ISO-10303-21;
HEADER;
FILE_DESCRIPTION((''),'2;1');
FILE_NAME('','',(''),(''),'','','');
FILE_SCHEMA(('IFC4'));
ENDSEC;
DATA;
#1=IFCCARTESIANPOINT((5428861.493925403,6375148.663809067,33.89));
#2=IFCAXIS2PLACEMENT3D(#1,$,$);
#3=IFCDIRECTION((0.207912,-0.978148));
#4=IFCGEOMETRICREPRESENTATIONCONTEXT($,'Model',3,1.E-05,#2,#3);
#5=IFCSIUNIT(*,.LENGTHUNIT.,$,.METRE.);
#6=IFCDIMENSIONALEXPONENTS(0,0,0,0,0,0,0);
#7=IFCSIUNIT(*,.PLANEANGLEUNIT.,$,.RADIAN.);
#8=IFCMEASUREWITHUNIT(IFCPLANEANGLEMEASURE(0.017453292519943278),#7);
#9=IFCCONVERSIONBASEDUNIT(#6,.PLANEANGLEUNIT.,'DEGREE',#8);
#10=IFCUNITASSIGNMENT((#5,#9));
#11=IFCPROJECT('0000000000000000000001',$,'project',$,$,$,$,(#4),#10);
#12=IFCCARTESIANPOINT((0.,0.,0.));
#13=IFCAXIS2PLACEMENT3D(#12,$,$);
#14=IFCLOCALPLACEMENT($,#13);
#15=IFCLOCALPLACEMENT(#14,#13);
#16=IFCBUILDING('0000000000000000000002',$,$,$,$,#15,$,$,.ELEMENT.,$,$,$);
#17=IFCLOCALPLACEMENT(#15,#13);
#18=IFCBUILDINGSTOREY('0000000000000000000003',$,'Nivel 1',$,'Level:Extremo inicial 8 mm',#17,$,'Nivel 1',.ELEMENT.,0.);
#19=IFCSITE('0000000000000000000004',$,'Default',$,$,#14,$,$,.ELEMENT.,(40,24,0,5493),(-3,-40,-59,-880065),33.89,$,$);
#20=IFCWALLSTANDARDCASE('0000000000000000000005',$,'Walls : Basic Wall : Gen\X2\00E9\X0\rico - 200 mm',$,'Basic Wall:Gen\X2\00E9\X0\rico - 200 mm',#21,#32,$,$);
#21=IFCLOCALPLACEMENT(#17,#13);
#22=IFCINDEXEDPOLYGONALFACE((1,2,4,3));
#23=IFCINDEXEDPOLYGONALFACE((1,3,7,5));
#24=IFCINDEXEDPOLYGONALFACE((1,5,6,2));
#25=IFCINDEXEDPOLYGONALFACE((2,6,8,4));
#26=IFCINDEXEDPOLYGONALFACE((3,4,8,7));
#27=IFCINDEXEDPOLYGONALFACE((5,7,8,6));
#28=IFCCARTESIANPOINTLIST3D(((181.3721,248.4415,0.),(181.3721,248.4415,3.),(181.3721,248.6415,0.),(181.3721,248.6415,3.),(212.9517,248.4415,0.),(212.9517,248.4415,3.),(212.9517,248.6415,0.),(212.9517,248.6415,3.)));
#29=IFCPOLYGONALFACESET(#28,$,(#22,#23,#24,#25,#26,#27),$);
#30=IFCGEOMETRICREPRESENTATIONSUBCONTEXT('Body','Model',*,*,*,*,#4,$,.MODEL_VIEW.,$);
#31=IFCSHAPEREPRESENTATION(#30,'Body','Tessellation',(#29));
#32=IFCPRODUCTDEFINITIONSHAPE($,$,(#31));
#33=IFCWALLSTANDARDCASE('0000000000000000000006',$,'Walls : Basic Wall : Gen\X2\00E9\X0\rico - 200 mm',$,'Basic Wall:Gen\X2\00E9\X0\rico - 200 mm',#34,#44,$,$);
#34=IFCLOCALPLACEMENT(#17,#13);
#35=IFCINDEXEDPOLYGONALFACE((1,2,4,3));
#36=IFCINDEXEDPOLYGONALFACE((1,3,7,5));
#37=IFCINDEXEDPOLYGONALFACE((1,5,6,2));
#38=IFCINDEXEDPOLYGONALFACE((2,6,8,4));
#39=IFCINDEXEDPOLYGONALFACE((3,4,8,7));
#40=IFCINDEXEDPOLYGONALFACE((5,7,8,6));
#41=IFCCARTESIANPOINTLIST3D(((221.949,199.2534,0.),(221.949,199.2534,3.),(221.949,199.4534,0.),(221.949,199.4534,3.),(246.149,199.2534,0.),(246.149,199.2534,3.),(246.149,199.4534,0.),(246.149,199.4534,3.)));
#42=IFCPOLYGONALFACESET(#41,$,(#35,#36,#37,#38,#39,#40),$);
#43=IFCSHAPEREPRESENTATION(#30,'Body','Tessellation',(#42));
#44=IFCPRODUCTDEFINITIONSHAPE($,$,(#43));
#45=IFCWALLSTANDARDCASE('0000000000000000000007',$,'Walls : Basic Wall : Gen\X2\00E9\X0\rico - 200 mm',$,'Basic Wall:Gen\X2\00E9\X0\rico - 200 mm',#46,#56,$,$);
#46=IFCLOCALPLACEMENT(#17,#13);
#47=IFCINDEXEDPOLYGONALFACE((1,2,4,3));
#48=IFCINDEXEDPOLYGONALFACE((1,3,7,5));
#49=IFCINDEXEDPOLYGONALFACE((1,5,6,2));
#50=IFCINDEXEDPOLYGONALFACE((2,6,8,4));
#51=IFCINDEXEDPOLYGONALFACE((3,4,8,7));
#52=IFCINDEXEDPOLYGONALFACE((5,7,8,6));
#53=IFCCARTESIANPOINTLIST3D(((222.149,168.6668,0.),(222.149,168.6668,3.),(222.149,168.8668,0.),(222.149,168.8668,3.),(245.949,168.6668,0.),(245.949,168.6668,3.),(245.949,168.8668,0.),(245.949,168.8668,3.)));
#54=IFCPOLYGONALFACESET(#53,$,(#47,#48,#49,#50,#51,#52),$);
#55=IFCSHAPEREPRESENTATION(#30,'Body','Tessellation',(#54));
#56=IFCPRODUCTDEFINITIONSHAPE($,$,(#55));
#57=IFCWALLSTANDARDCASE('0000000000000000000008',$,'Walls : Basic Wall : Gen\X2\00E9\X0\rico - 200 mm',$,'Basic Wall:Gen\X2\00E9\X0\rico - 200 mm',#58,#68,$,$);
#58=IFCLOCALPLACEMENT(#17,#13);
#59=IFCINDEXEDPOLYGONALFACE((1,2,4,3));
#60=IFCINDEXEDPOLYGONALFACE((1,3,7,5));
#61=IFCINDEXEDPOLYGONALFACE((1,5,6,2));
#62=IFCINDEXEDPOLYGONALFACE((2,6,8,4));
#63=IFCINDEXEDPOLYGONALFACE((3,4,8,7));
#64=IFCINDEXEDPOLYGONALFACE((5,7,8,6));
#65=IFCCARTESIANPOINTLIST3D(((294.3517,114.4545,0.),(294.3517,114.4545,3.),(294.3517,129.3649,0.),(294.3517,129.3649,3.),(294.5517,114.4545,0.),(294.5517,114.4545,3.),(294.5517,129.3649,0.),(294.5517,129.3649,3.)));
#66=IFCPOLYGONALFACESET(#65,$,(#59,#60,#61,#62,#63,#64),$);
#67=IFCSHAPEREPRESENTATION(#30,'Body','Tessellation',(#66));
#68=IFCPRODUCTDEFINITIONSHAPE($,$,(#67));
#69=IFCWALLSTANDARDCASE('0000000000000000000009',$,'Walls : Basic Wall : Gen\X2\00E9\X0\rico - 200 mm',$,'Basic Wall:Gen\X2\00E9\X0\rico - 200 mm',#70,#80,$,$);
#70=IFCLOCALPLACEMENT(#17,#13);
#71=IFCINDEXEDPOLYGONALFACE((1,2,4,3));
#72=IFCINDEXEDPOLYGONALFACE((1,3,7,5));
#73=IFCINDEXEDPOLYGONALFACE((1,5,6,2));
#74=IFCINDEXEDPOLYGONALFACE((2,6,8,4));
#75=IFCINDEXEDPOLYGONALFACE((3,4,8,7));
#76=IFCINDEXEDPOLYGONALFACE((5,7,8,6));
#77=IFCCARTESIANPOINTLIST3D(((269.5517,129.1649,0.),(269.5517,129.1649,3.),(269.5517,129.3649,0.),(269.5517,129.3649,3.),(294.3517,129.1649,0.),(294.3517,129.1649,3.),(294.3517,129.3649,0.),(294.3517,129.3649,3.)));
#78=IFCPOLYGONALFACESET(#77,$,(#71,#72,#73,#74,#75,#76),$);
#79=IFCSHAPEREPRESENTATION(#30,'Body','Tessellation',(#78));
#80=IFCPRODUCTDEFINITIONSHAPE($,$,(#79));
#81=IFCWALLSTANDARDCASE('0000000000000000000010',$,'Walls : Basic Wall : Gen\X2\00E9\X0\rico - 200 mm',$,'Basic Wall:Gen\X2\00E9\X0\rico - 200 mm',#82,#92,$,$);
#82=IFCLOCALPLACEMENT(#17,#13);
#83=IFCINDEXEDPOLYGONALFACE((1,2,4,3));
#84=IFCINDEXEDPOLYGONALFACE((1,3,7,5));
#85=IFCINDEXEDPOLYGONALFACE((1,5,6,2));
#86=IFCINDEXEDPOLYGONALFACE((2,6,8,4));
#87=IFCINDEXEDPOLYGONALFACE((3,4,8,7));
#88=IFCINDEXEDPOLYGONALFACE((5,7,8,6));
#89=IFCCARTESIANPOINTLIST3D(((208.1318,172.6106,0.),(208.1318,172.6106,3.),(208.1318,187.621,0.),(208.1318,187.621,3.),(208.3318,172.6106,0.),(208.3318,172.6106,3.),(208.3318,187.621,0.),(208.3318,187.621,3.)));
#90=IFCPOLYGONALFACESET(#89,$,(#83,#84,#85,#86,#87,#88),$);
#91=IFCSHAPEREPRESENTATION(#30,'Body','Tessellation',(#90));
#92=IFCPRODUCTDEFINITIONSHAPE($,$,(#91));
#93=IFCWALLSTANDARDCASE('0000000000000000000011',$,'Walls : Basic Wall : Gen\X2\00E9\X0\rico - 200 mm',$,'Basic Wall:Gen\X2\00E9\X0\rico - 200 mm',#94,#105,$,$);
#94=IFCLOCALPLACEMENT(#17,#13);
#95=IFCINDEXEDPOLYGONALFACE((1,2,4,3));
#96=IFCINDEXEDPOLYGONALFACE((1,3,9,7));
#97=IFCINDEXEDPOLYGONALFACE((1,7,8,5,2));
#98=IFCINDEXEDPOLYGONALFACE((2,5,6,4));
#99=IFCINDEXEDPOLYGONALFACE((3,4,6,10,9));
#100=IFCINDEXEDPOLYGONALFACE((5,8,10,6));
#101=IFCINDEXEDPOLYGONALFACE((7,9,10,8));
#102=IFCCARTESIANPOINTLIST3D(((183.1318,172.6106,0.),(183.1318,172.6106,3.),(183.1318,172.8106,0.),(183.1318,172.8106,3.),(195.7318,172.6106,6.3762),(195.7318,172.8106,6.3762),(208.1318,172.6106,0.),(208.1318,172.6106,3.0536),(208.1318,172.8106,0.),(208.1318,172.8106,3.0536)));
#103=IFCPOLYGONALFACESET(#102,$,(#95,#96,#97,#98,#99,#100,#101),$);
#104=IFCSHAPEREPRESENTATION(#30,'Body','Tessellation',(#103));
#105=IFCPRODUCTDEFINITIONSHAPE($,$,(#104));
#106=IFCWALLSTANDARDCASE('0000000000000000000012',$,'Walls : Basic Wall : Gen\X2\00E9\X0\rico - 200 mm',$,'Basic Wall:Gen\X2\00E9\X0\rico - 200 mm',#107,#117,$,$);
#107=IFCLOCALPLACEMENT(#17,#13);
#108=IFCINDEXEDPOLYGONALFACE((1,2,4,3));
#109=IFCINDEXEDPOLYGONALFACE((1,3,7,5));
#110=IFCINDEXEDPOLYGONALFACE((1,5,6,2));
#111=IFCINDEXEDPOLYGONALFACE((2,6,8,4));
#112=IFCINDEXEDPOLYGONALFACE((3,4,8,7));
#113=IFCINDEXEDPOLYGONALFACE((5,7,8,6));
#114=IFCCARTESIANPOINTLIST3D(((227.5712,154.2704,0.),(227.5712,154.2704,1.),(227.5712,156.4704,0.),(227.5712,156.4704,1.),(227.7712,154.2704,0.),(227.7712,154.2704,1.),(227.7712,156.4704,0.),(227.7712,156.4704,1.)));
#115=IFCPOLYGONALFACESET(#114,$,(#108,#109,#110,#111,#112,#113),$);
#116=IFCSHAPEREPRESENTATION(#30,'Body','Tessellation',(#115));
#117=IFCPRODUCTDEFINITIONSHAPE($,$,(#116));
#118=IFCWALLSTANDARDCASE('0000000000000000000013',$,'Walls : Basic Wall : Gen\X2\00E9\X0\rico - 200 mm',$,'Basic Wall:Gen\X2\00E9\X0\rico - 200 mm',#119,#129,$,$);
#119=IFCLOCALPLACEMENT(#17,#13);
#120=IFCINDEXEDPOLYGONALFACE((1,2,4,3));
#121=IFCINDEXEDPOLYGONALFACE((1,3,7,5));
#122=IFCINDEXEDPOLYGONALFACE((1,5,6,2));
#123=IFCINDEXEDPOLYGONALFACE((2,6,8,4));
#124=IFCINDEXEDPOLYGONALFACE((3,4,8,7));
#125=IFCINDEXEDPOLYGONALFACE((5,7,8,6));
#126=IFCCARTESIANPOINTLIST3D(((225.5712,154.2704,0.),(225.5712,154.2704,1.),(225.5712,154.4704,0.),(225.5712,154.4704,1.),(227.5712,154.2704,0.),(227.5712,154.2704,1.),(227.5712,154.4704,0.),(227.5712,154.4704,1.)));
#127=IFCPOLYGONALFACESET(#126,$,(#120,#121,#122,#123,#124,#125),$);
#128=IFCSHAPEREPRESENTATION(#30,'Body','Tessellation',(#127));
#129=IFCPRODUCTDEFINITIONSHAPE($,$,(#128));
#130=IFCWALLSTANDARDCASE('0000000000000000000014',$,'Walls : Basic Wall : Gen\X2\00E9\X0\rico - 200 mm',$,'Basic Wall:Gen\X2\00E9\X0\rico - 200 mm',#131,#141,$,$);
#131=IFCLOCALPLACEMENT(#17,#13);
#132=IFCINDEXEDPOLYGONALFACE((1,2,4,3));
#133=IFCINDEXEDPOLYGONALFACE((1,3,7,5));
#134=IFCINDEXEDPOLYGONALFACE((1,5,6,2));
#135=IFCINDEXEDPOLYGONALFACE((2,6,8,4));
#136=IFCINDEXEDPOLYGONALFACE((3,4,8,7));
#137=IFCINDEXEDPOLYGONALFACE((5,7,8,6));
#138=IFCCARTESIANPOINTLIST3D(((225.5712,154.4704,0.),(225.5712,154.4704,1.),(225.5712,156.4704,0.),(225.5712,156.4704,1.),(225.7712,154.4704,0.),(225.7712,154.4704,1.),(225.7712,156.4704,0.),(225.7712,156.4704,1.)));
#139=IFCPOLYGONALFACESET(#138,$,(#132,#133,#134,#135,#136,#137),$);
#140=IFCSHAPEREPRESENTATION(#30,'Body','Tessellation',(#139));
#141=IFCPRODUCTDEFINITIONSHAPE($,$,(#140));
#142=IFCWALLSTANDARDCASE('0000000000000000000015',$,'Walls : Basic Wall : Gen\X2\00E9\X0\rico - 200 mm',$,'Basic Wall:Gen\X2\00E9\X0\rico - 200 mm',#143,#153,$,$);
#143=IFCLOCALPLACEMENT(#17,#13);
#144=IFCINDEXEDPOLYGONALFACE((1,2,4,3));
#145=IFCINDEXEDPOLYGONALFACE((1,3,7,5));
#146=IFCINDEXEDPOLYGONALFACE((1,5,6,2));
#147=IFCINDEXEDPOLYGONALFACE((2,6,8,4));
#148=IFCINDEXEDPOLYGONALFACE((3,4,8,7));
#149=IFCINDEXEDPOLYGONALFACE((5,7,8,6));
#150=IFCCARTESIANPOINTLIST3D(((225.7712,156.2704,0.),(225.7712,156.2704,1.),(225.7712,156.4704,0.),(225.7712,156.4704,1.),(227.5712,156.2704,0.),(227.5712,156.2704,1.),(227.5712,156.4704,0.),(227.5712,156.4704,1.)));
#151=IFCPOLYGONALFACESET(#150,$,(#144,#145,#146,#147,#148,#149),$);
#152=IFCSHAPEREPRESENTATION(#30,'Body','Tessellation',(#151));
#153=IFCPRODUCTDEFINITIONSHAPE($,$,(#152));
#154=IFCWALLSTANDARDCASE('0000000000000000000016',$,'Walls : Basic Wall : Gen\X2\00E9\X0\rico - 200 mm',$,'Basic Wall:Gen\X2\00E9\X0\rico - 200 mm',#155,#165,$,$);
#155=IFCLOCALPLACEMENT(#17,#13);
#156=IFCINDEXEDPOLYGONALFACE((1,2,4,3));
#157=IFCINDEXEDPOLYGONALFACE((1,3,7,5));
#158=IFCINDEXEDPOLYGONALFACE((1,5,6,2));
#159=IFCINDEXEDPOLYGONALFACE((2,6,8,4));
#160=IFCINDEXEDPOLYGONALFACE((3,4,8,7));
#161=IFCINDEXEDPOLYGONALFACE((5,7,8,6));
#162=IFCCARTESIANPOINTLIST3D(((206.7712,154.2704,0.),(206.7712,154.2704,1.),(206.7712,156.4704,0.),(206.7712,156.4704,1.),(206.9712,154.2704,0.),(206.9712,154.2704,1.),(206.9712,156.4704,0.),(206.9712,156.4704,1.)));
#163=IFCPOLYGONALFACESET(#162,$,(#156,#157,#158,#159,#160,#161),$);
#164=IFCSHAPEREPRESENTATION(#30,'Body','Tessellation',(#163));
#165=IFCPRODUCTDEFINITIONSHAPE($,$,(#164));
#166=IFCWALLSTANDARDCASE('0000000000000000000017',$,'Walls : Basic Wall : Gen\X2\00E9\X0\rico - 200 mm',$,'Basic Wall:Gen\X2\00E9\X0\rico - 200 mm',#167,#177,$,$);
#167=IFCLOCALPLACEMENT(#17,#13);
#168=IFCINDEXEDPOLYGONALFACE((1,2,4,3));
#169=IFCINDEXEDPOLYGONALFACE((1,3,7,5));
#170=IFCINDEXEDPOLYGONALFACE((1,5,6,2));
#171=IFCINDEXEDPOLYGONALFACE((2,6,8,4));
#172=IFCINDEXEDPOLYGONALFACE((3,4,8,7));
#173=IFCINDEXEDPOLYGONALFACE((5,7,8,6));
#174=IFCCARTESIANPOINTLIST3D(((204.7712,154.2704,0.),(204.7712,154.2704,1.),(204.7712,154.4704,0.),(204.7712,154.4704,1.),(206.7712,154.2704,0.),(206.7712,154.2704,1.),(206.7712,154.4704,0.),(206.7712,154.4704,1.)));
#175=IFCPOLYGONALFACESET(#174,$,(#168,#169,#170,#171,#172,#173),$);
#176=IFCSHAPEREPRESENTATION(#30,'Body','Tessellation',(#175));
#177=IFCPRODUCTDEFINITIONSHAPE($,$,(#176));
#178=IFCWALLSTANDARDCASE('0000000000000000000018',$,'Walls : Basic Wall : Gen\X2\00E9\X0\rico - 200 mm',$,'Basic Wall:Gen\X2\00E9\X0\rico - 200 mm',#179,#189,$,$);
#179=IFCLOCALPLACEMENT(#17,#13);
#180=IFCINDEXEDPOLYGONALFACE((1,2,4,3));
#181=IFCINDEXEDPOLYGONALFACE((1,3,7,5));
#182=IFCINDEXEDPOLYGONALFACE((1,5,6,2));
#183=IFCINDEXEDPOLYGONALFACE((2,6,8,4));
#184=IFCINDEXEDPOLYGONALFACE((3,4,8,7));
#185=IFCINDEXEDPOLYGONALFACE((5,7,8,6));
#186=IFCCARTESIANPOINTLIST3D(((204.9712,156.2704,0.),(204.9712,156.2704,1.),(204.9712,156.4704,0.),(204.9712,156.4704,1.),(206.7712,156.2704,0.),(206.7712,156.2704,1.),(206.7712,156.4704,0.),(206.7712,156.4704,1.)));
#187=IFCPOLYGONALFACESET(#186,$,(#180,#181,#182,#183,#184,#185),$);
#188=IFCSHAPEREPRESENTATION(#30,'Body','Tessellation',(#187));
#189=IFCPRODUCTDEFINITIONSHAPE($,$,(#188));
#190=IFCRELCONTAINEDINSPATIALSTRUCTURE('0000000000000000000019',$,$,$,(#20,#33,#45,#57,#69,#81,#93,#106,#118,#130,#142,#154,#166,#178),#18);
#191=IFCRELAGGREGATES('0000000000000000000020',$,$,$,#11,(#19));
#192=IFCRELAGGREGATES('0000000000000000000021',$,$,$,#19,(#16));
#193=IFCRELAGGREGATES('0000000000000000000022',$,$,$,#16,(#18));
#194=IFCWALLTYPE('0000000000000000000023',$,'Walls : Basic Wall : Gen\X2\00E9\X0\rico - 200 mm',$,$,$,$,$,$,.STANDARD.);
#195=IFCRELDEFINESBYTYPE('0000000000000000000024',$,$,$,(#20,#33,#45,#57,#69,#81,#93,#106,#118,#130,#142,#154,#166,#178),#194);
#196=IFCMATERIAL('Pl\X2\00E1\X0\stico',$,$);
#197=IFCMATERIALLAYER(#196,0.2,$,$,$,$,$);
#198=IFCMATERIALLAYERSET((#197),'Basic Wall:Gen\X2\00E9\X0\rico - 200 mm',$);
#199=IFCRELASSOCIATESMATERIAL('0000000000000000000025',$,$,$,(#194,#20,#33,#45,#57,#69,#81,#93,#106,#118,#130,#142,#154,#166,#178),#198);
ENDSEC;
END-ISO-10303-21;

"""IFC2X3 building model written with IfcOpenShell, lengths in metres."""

from ifc_helpers import new_model, entity, si_unit, converted_unit, direction, frame, frame_2d, origin, place, context, subcontext, project, spatial, polyline, rectangle, extrude, clip, bounded_halfspace, material, layer, layer_set, layer_usage, type_object, element, save


model = new_model("IFC2X3")

# Units and contexts
model_context = context("Model", 3, precision=1e-05, world=frame((5428861.493925403, 6375148.663809067, 33.89)), true_north=direction((0.207912, -0.978148)))
body_context = subcontext(model_context, "Body", "Model", "MODEL_VIEW")
ifc_project = project(units=[si_unit("LENGTHUNIT", "METRE"), converted_unit("PLANEANGLEUNIT", "DEGREE", entity("IfcPlaneAngleMeasure", 0.017453292519943278), si_unit("PLANEANGLEUNIT", "RADIAN"), dimensions=[0, 0, 0, 0, 0, 0, 0])], contexts=[model_context])

# Site, building, storey
site_placement = place(None, origin())
site = spatial("IfcSite", under=ifc_project, at=site_placement, Name="Default", CompositionType="ELEMENT", RefLatitude=(40, 24, 0, 5493), RefLongitude=(-3, -40, -59, -880065), RefElevation=33.89)
building_placement = place(site_placement, origin())
building = spatial("IfcBuilding", under=site, at=building_placement, CompositionType="ELEMENT")
storey_placement = place(building_placement, origin())
storey = spatial("IfcBuildingStorey", under=building, at=storey_placement, Name="Nivel 1", ObjectType="Level:Extremo inicial 8 mm", LongName="Nivel 1", CompositionType="ELEMENT", Elevation=0.0)

# Walls
ifc_material_1 = material(Name="Plástico")
ifc_layer_1 = layer(ifc_material_1, 0.2)
ifc_layer_set_1 = layer_set([ifc_layer_1], Name="Basic Wall:Genérico - 200 mm")
wall_type = type_object("IfcWallType", Name="Walls : Basic Wall : Genérico - 200 mm", PredefinedType="STANDARD", material=ifc_layer_set_1)
ifc_layer_usage_1 = layer_usage(ifc_layer_set_1, "AXIS2", "NEGATIVE", 0.1)
wall_1_placement = place(storey_placement, frame((212.9517, 248.5415, 0.0), z_axis=(0.0, 0.0, 1.0), x_axis=(-1.0, 0.0, 0.0)))
element("IfcWallStandardCase", 1, at=wall_1_placement, inside=storey, type_object=wall_type, material=ifc_layer_usage_1, Name="Walls : Basic Wall : Genérico - 200 mm", ObjectType="Basic Wall:Genérico - 200 mm", context=body_context, shape_type="SweptSolid", body=[
    extrude(rectangle(XDim=31.5796, YDim=0.2, at=frame_2d((15.7898, 0.0), x_axis=(-1.0, 0.0))), origin(), (0.0, 0.0, 1.0), 3.0),
])
ifc_layer_usage_2 = layer_usage(ifc_layer_set_1, "AXIS2", "NEGATIVE", 0.1)
wall_2_placement = place(storey_placement, frame((221.949, 199.3534, 0.0)))
element("IfcWallStandardCase", 2, at=wall_2_placement, inside=storey, type_object=wall_type, material=ifc_layer_usage_2, Name="Walls : Basic Wall : Genérico - 200 mm", ObjectType="Basic Wall:Genérico - 200 mm", context=body_context, shape_type="SweptSolid", body=[
    extrude(rectangle(XDim=24.2, YDim=0.2, at=frame_2d((12.1, 0.0), x_axis=(-1.0, 0.0))), origin(), (0.0, 0.0, 1.0), 3.0),
])
ifc_layer_usage_3 = layer_usage(ifc_layer_set_1, "AXIS2", "NEGATIVE", 0.1)
wall_3_placement = place(storey_placement, frame((245.949, 168.7668, 0.0), z_axis=(0.0, 0.0, 1.0), x_axis=(-1.0, 0.0, 0.0)))
element("IfcWallStandardCase", 3, at=wall_3_placement, inside=storey, type_object=wall_type, material=ifc_layer_usage_3, Name="Walls : Basic Wall : Genérico - 200 mm", ObjectType="Basic Wall:Genérico - 200 mm", context=body_context, shape_type="SweptSolid", body=[
    extrude(rectangle(XDim=23.8, YDim=0.2, at=frame_2d((11.9, 0.0), x_axis=(-1.0, 0.0))), origin(), (0.0, 0.0, 1.0), 3.0),
])
ifc_layer_usage_4 = layer_usage(ifc_layer_set_1, "AXIS2", "NEGATIVE", 0.1)
wall_4_placement = place(storey_placement, frame((294.4517, 129.3649, 0.0), z_axis=(0.0, 0.0, 1.0), x_axis=(0.0, -1.0, 0.0)))
element("IfcWallStandardCase", 4, at=wall_4_placement, inside=storey, type_object=wall_type, material=ifc_layer_usage_4, Name="Walls : Basic Wall : Genérico - 200 mm", ObjectType="Basic Wall:Genérico - 200 mm", context=body_context, shape_type="SweptSolid", body=[
    extrude(rectangle(XDim=14.9104, YDim=0.2, at=frame_2d((7.4552, 0.0), x_axis=(-1.0, 0.0))), origin(), (0.0, 0.0, 1.0), 3.0),
])
ifc_layer_usage_5 = layer_usage(ifc_layer_set_1, "AXIS2", "NEGATIVE", 0.1)
wall_5_placement = place(storey_placement, frame((294.3517, 129.2649, 0.0), z_axis=(0.0, 0.0, 1.0), x_axis=(-1.0, 0.0, 0.0)))
element("IfcWallStandardCase", 5, at=wall_5_placement, inside=storey, type_object=wall_type, material=ifc_layer_usage_5, Name="Walls : Basic Wall : Genérico - 200 mm", ObjectType="Basic Wall:Genérico - 200 mm", context=body_context, shape_type="SweptSolid", body=[
    extrude(rectangle(XDim=24.8, YDim=0.2, at=frame_2d((12.4, 0.0), x_axis=(-1.0, 0.0))), origin(), (0.0, 0.0, 1.0), 3.0),
])
ifc_layer_usage_6 = layer_usage(ifc_layer_set_1, "AXIS2", "NEGATIVE", 0.1)
wall_6_placement = place(storey_placement, frame((208.2318, 187.621, 0.0), z_axis=(0.0, 0.0, 1.0), x_axis=(0.0, -1.0, 0.0)))
element("IfcWallStandardCase", 6, at=wall_6_placement, inside=storey, type_object=wall_type, material=ifc_layer_usage_6, Name="Walls : Basic Wall : Genérico - 200 mm", ObjectType="Basic Wall:Genérico - 200 mm", context=body_context, shape_type="SweptSolid", body=[
    extrude(rectangle(XDim=15.0104, YDim=0.2, at=frame_2d((7.5052, 0.0), x_axis=(-1.0, 0.0))), origin(), (0.0, 0.0, 1.0), 3.0),
])
ifc_layer_usage_7 = layer_usage(ifc_layer_set_1, "AXIS2", "NEGATIVE", 0.1)
wall_7_placement = place(storey_placement, frame((208.1318, 172.7106, 0.0), z_axis=(0.0, 0.0, 1.0), x_axis=(-1.0, 0.0, 0.0)))
element("IfcWallStandardCase", 7, at=wall_7_placement, inside=storey, type_object=wall_type, material=ifc_layer_usage_7, Name="Walls : Basic Wall : Genérico - 200 mm", ObjectType="Basic Wall:Genérico - 200 mm", context=body_context, shape_type="Clipping", body=[
    clip(clip(extrude(rectangle(XDim=25.0, YDim=0.2, at=frame_2d((12.5, 0.0), x_axis=(-1.0, 0.0))), origin(), (0.0, 0.0, 1.0), 6.3762), bounded_halfspace(frame((0.0, -0.1, 3.0536), z_axis=(-0.258819, 0.0, 0.965926), x_axis=(0.0, -1.0, 0.0)), False, frame((0.0, -0.1, 3.0536)), polyline([(0.0, 0.0), (12.4, 0.0), (12.4, 0.2), (0.0, 0.2), (0.0, 0.0)]))), bounded_halfspace(frame((12.4, -0.1, 6.3762), z_axis=(0.258819, 0.0, 0.965926), x_axis=(0.0, 1.0, 0.0)), False, frame((12.4, -0.1, 6.3762)), polyline([(0.0, 0.0), (12.6, 0.0), (12.6, 0.2), (0.0, 0.2), (0.0, 0.0)]))),
])
ifc_layer_usage_8 = layer_usage(ifc_layer_set_1, "AXIS2", "NEGATIVE", 0.1)
wall_8_placement = place(storey_placement, frame((227.6712, 156.4704, 0.0), z_axis=(0.0, 0.0, 1.0), x_axis=(0.0, -1.0, 0.0)))
element("IfcWallStandardCase", 8, at=wall_8_placement, inside=storey, type_object=wall_type, material=ifc_layer_usage_8, Name="Walls : Basic Wall : Genérico - 200 mm", ObjectType="Basic Wall:Genérico - 200 mm", context=body_context, shape_type="SweptSolid", body=[
    extrude(rectangle(XDim=2.2, YDim=0.2, at=frame_2d((1.1, 0.0), x_axis=(-1.0, 0.0))), origin(), (0.0, 0.0, 1.0), 1.0),
])
ifc_layer_usage_9 = layer_usage(ifc_layer_set_1, "AXIS2", "NEGATIVE", 0.1)
wall_9_placement = place(storey_placement, frame((227.5712, 154.3704, 0.0), z_axis=(0.0, 0.0, 1.0), x_axis=(-1.0, 0.0, 0.0)))
element("IfcWallStandardCase", 9, at=wall_9_placement, inside=storey, type_object=wall_type, material=ifc_layer_usage_9, Name="Walls : Basic Wall : Genérico - 200 mm", ObjectType="Basic Wall:Genérico - 200 mm", context=body_context, shape_type="SweptSolid", body=[
    extrude(rectangle(XDim=2.0, YDim=0.2, at=frame_2d((1.0, 0.0), x_axis=(-1.0, 0.0))), origin(), (0.0, 0.0, 1.0), 1.0),
])
ifc_layer_usage_10 = layer_usage(ifc_layer_set_1, "AXIS2", "NEGATIVE", 0.1)
wall_10_placement = place(storey_placement, frame((225.6712, 154.4704, 0.0), z_axis=(0.0, 0.0, 1.0), x_axis=(0.0, 1.0, 0.0)))
element("IfcWallStandardCase", 10, at=wall_10_placement, inside=storey, type_object=wall_type, material=ifc_layer_usage_10, Name="Walls : Basic Wall : Genérico - 200 mm", ObjectType="Basic Wall:Genérico - 200 mm", context=body_context, shape_type="SweptSolid", body=[
    extrude(rectangle(XDim=2.0, YDim=0.2, at=frame_2d((1.0, 0.0), x_axis=(-1.0, 0.0))), origin(), (0.0, 0.0, 1.0), 1.0),
])
ifc_layer_usage_11 = layer_usage(ifc_layer_set_1, "AXIS2", "NEGATIVE", 0.1)
wall_11_placement = place(storey_placement, frame((225.7712, 156.3704, 0.0)))
element("IfcWallStandardCase", 11, at=wall_11_placement, inside=storey, type_object=wall_type, material=ifc_layer_usage_11, Name="Walls : Basic Wall : Genérico - 200 mm", ObjectType="Basic Wall:Genérico - 200 mm", context=body_context, shape_type="SweptSolid", body=[
    extrude(rectangle(XDim=1.8, YDim=0.2, at=frame_2d((0.9, 0.0), x_axis=(-1.0, 0.0))), origin(), (0.0, 0.0, 1.0), 1.0),
])
ifc_layer_usage_12 = layer_usage(ifc_layer_set_1, "AXIS2", "NEGATIVE", 0.1)
wall_12_placement = place(storey_placement, frame((206.8712, 156.4704, 0.0), z_axis=(0.0, 0.0, 1.0), x_axis=(0.0, -1.0, 0.0)))
element("IfcWallStandardCase", 12, at=wall_12_placement, inside=storey, type_object=wall_type, material=ifc_layer_usage_12, Name="Walls : Basic Wall : Genérico - 200 mm", ObjectType="Basic Wall:Genérico - 200 mm", context=body_context, shape_type="SweptSolid", body=[
    extrude(rectangle(XDim=2.2, YDim=0.2, at=frame_2d((1.1, 0.0), x_axis=(-1.0, 0.0))), origin(), (0.0, 0.0, 1.0), 1.0),
])
ifc_layer_usage_13 = layer_usage(ifc_layer_set_1, "AXIS2", "NEGATIVE", 0.1)
wall_13_placement = place(storey_placement, frame((206.7712, 154.3704, 0.0), z_axis=(0.0, 0.0, 1.0), x_axis=(-1.0, 0.0, 0.0)))
element("IfcWallStandardCase", 13, at=wall_13_placement, inside=storey, type_object=wall_type, material=ifc_layer_usage_13, Name="Walls : Basic Wall : Genérico - 200 mm", ObjectType="Basic Wall:Genérico - 200 mm", context=body_context, shape_type="SweptSolid", body=[
    extrude(rectangle(XDim=2.0, YDim=0.2, at=frame_2d((1.0, 0.0), x_axis=(-1.0, 0.0))), origin(), (0.0, 0.0, 1.0), 1.0),
])
ifc_layer_usage_14 = layer_usage(ifc_layer_set_1, "AXIS2", "NEGATIVE", 0.1)
wall_14_placement = place(storey_placement, frame((204.9712, 156.3704, 0.0)))
element("IfcWallStandardCase", 14, at=wall_14_placement, inside=storey, type_object=wall_type, material=ifc_layer_usage_14, Name="Walls : Basic Wall : Genérico - 200 mm", ObjectType="Basic Wall:Genérico - 200 mm", context=body_context, shape_type="SweptSolid", body=[
    extrude(rectangle(XDim=1.8, YDim=0.2, at=frame_2d((0.9, 0.0), x_axis=(-1.0, 0.0))), origin(), (0.0, 0.0, 1.0), 1.0),
])

save(model, "model.ifc")
